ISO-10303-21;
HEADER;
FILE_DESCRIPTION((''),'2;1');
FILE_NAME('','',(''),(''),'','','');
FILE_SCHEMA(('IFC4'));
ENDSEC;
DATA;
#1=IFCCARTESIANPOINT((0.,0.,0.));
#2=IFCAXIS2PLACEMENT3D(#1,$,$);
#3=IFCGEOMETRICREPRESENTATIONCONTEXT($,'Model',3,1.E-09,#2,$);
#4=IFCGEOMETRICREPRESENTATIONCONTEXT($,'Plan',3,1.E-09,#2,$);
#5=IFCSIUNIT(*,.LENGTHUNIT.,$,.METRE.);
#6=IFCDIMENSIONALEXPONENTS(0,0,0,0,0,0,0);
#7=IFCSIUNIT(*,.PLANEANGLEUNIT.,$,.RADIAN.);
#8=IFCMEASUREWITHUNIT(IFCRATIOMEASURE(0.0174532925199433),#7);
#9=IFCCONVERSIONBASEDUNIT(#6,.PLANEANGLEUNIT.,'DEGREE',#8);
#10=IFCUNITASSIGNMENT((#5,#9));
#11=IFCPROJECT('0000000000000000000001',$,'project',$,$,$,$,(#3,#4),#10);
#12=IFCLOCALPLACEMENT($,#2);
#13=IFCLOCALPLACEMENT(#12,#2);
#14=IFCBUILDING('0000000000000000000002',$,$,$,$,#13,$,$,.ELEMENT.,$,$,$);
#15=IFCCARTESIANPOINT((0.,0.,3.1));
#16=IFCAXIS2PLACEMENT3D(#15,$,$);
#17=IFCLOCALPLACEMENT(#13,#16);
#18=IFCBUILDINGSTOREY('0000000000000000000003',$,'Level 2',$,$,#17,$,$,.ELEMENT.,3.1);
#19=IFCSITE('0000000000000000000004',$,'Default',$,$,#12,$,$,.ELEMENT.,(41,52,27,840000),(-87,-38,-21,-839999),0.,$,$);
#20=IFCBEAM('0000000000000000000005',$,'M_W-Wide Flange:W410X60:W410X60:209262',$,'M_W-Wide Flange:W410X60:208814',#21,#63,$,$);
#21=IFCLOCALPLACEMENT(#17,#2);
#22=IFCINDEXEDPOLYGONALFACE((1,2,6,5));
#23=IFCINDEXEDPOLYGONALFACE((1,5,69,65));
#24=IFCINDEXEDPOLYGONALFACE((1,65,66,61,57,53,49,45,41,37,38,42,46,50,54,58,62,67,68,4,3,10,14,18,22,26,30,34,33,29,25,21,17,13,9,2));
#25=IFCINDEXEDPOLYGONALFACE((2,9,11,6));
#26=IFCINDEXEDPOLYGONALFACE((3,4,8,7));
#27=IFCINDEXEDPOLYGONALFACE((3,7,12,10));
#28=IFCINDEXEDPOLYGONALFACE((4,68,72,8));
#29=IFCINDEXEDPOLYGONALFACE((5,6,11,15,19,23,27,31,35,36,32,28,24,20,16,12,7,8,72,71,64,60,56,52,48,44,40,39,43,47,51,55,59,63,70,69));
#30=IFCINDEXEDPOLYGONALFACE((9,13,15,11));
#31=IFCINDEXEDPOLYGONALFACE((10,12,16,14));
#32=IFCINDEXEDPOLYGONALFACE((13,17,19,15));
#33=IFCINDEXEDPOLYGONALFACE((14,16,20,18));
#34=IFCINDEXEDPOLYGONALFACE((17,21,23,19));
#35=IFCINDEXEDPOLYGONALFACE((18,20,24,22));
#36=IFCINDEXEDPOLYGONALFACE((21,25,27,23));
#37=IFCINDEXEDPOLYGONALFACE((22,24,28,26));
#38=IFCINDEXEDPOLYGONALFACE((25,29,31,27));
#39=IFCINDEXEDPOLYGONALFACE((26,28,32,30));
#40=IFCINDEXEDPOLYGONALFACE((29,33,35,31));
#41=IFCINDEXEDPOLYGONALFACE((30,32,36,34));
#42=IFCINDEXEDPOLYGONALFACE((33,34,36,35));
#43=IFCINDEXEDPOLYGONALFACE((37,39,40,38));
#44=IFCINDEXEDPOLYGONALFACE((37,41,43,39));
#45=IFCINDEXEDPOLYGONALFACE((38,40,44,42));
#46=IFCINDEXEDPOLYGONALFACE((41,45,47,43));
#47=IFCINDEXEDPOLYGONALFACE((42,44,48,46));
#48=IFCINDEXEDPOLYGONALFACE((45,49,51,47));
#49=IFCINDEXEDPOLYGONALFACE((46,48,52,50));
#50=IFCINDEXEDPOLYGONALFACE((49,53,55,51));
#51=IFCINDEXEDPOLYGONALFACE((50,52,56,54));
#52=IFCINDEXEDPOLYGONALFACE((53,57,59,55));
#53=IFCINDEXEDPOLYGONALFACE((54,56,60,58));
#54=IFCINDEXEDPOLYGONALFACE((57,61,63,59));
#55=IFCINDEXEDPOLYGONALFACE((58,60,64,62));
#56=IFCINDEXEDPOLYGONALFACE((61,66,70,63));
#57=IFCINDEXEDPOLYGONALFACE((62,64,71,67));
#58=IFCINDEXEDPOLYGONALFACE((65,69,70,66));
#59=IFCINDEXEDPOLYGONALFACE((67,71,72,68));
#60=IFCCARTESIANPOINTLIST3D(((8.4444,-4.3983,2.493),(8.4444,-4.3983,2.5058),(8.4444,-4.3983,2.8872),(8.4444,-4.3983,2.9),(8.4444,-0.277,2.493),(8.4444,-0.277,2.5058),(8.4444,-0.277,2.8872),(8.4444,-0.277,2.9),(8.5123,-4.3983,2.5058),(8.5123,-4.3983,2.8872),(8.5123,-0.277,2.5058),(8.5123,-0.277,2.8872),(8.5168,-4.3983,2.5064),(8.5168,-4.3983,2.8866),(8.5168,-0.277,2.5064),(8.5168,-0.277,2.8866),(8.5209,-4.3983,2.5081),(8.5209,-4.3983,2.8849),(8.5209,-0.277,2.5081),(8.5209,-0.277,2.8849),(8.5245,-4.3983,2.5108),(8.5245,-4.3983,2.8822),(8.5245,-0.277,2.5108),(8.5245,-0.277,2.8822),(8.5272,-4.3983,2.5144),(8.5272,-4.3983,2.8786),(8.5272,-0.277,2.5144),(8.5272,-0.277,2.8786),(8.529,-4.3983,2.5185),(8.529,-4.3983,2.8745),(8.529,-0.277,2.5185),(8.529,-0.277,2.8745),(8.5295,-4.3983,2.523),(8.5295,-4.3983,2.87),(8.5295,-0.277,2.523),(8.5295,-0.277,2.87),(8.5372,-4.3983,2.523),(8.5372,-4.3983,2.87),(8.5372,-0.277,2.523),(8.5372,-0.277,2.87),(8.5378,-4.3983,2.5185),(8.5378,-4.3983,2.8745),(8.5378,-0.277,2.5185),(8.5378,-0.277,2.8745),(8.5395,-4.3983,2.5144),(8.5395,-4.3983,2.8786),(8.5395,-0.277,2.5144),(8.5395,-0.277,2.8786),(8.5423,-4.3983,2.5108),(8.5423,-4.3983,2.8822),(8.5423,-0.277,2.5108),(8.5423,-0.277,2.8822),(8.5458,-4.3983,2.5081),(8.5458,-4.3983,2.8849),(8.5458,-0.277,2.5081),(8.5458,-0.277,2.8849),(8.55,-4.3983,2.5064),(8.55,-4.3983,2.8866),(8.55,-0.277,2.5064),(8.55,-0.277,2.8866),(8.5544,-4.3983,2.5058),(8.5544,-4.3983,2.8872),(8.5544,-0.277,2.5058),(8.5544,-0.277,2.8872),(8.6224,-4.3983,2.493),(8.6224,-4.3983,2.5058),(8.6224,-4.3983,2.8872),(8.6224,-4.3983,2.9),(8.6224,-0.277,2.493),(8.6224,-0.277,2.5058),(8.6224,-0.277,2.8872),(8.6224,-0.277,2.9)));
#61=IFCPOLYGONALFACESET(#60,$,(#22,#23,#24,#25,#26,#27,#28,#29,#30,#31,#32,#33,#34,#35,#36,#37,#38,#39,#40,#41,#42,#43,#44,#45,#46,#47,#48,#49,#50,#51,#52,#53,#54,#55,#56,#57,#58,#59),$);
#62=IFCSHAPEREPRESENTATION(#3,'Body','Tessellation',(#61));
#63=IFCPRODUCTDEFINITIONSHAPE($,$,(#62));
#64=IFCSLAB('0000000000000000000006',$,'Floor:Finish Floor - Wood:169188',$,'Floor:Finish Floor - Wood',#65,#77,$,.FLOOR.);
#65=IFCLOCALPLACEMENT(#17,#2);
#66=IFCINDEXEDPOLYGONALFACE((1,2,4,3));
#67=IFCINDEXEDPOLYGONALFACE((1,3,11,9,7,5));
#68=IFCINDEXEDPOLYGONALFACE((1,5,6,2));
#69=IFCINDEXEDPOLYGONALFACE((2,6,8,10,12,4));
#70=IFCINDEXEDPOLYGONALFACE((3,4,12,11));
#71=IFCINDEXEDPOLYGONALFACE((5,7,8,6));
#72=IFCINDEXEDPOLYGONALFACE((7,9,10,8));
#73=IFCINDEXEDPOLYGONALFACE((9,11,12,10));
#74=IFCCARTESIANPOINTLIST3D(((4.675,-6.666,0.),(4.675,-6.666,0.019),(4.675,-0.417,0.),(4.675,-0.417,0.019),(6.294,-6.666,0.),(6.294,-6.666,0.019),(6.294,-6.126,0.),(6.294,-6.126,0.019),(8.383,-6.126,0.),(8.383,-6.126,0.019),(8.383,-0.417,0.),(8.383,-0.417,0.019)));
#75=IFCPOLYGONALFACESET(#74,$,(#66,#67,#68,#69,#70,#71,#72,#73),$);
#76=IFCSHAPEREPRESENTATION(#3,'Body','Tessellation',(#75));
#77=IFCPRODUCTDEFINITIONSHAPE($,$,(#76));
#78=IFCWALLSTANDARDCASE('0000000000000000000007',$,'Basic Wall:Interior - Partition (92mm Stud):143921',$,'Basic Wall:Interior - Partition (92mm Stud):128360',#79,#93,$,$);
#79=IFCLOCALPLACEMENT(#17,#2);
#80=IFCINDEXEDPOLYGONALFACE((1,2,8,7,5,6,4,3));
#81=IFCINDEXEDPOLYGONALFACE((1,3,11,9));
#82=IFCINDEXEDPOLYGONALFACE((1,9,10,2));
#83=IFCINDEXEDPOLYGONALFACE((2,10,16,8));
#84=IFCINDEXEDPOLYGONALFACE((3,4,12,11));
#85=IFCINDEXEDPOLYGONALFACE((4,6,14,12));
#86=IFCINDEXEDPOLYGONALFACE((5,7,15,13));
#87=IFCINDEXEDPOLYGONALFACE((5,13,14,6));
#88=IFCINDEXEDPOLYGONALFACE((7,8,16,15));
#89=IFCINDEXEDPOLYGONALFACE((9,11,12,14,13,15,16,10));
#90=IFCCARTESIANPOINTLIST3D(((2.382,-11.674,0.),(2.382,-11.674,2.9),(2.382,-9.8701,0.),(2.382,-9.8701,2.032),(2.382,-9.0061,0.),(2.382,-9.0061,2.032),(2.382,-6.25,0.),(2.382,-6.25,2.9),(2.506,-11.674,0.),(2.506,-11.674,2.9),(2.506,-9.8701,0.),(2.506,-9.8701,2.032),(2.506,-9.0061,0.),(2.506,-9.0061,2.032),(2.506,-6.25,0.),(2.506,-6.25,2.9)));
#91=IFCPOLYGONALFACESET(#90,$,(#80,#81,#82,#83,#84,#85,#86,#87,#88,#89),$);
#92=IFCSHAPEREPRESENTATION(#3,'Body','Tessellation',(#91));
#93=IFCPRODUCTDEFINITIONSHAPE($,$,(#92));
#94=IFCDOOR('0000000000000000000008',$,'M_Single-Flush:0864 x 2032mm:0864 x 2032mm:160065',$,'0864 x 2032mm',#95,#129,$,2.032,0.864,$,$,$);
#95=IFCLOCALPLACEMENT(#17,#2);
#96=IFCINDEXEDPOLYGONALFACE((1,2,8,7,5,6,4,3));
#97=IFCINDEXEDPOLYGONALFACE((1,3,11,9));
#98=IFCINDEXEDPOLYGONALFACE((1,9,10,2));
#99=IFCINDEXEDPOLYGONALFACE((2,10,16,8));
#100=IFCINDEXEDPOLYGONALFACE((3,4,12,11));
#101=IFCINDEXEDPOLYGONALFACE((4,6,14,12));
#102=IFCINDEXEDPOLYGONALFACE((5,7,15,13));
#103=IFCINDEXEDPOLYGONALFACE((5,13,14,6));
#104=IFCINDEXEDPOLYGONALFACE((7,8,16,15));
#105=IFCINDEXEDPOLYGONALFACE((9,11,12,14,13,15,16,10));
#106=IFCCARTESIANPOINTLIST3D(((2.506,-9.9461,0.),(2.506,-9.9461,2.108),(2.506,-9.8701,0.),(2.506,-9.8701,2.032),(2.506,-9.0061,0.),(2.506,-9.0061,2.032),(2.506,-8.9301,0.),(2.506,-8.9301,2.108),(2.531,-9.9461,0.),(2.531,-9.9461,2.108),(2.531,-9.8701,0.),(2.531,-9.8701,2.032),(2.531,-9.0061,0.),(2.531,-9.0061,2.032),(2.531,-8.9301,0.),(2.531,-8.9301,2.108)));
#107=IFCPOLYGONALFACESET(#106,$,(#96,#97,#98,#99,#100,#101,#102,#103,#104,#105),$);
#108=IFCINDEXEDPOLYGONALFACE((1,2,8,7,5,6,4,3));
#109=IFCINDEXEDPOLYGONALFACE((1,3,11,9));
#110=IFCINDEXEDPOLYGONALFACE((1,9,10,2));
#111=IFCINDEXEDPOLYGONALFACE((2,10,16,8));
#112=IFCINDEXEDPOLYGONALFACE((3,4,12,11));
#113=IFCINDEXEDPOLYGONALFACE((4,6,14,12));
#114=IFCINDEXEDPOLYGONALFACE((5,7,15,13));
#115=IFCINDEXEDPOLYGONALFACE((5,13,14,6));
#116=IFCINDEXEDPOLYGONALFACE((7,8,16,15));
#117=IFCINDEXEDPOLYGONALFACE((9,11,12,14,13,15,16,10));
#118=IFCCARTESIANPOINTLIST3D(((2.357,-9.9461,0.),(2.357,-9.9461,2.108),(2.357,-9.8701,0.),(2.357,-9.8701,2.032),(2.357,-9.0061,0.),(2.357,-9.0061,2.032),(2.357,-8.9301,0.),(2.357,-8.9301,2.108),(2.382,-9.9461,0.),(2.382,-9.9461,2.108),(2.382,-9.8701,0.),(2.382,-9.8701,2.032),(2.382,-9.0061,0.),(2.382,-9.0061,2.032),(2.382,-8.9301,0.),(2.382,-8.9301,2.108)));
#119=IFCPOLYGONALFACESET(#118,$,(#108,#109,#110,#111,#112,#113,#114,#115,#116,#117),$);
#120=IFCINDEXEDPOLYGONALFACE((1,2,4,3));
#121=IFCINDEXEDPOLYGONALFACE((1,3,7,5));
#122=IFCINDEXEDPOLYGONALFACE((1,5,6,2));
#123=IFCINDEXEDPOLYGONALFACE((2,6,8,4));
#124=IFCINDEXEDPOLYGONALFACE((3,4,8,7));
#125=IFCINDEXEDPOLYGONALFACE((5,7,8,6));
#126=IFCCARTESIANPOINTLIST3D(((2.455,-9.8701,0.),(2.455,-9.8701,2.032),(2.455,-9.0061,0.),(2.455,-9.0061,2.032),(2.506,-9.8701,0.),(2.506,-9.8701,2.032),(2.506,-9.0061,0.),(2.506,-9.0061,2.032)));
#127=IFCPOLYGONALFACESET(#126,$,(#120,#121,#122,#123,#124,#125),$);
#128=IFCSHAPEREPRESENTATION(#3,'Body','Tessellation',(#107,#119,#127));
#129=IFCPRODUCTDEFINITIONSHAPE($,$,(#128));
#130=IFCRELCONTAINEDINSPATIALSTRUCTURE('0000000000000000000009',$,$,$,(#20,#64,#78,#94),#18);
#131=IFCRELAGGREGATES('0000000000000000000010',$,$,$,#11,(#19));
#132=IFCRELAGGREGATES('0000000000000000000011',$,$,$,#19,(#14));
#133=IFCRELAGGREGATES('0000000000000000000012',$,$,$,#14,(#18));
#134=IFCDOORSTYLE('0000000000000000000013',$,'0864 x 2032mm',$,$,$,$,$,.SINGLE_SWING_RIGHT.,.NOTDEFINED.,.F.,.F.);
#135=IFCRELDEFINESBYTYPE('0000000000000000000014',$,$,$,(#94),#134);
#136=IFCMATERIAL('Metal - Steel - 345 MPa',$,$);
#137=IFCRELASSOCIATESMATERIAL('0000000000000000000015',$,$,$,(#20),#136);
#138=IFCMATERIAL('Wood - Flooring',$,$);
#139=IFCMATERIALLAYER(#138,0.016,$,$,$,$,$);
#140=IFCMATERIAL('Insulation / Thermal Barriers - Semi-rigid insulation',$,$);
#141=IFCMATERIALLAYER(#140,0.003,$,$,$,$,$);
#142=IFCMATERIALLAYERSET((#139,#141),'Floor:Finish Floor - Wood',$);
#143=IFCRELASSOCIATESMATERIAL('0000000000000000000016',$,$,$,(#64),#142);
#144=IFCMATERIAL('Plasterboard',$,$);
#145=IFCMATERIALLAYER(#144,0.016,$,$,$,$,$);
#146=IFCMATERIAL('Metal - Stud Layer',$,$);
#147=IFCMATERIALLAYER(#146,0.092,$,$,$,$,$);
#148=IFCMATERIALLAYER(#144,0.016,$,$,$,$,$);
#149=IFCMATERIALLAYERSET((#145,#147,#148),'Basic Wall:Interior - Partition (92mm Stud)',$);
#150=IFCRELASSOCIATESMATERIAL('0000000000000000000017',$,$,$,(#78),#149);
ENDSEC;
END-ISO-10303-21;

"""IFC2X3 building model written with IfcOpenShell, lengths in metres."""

from ifc_helpers import new_model, entity, si_unit, converted_unit, frame, frame_2d, origin, origin_2d_with_axis, place, context, project, spatial, polyline, circle_curve, parameter, trimmed, segment, composite_curve, rectangle, outline, extrude, source, transform, mapped, material, layer, layer_set, layer_usage, type_object, type_shapes, element, fill, save


model = new_model("IFC2X3")

# Units and contexts
model_context = context("Model", 3, precision=1e-09, world=origin())
plan_context = context("Plan", 3, precision=1e-09, world=origin())
ifc_project = project(units=[si_unit("LENGTHUNIT", "METRE"), converted_unit("PLANEANGLEUNIT", "DEGREE", entity("IfcRatioMeasure", 0.0174532925199433), si_unit("PLANEANGLEUNIT", "RADIAN"), dimensions=[0, 0, 0, 0, 0, 0, 0])], contexts=[model_context, plan_context])

# Site, building, storey
site_placement = place(None, origin())
site = spatial("IfcSite", under=ifc_project, at=site_placement, Name="Default", CompositionType="ELEMENT", RefLatitude=(41, 52, 27, 840000), RefLongitude=(-87, -38, -21, -839999), RefElevation=0.0)
building_placement = place(site_placement, origin())
building = spatial("IfcBuilding", under=site, at=building_placement, CompositionType="ELEMENT")
storey_placement = place(building_placement, frame((0.0, 0.0, 3.1)))
storey = spatial("IfcBuildingStorey", under=building, at=storey_placement, Name="Level 2", CompositionType="ELEMENT", Elevation=3.1)

# Beam
ifc_material_1 = material(Name="Metal - Steel - 345 MPa")
beam_1_placement = place(storey_placement, frame((8.5334, -4.3983, 2.9)))
element("IfcBeam", 1, at=beam_1_placement, inside=storey, material=ifc_material_1, Name="M_W-Wide Flange:W410X60:W410X60:209262", ObjectType="M_W-Wide Flange:W410X60:208814", context=model_context, shape_type="SweptSolid", body=[
    extrude(outline(composite_curve([segment(polyline([(-0.089, -0.1907), (-0.089, -0.2035)]), True, "CONTINUOUS"), segment(polyline([(-0.089, -0.2035), (0.089, -0.2035)]), True, "CONTINUOUS"), segment(polyline([(0.089, -0.2035), (0.089, -0.1907)]), True, "CONTINUOUS"), segment(polyline([(0.089, -0.1907), (0.021, -0.1907)]), True, "CONTINUOUS"), segment(trimmed(circle_curve(frame_2d((0.021, -0.1735), x_axis=(0.0, -1.0)), 0.0172), [parameter(270.0)], [parameter(360.0)], True, "PARAMETER"), False, "CONTINUOUS"), segment(polyline([(0.0038, -0.1735), (0.0038, 0.1735)]), True, "CONTINUOUS"), segment(trimmed(circle_curve(frame_2d((0.021, 0.1735), x_axis=(-1.0, 0.0)), 0.0172), [parameter(270.0)], [parameter(360.0)], True, "PARAMETER"), False, "CONTINUOUS"), segment(polyline([(0.021, 0.1907), (0.089, 0.1907)]), True, "CONTINUOUS"), segment(polyline([(0.089, 0.1907), (0.089, 0.2035)]), True, "CONTINUOUS"), segment(polyline([(0.089, 0.2035), (-0.089, 0.2035)]), True, "CONTINUOUS"), segment(polyline([(-0.089, 0.2035), (-0.089, 0.1907)]), True, "CONTINUOUS"), segment(polyline([(-0.089, 0.1907), (-0.0211, 0.1907)]), True, "CONTINUOUS"), segment(trimmed(circle_curve(frame_2d((-0.0211, 0.1735), x_axis=(0.0, 1.0)), 0.0172), [parameter(270.0)], [parameter(0.0)], True, "PARAMETER"), False, "CONTINUOUS"), segment(polyline([(-0.0039, 0.1735), (-0.0039, -0.1735)]), True, "CONTINUOUS"), segment(trimmed(circle_curve(frame_2d((-0.0211, -0.1735), x_axis=(1.0, 0.0)), 0.0172), [parameter(270.0)], [parameter(0.0)], True, "PARAMETER"), False, "CONTINUOUS"), segment(polyline([(-0.0211, -0.1907), (-0.089, -0.1907)]), True, "CONTINUOUS")], self_intersect=False)), frame((0.0, 0.0, -0.2035), z_axis=(0.0, -1.0, 0.0), x_axis=(1.0, 0.0, 0.0)), (0.0, 0.0, -1.0), 4.1213),
])

# Slab
ifc_material_2 = material(Name="Wood - Flooring")
ifc_layer_1 = layer(ifc_material_2, 0.016)
ifc_material_3 = material(Name="Insulation / Thermal Barriers - Semi-rigid insulation")
ifc_layer_2 = layer(ifc_material_3, 0.003)
ifc_layer_set_1 = layer_set([ifc_layer_1, ifc_layer_2], Name="Floor:Finish Floor - Wood")
ifc_layer_usage_1 = layer_usage(ifc_layer_set_1, "AXIS3", "POSITIVE", 0.0)
slab_placement = place(storey_placement, frame((4.675, -6.666, 0.0)))
element("IfcSlab", 2, at=slab_placement, inside=storey, material=ifc_layer_usage_1, Name="Floor:Finish Floor - Wood:169188", ObjectType="Floor:Finish Floor - Wood", PredefinedType="FLOOR", context=model_context, shape_type="SweptSolid", body=[
    extrude(outline(polyline([(-1.854, 3.1245), (-1.854, -2.5845), (0.235, -2.5845), (0.235, -3.1245), (1.854, -3.1245), (1.854, 3.1245), (-1.854, 3.1245)])), frame((1.854, 3.1245, 0.019), z_axis=(0.0, 0.0, -1.0), x_axis=(-1.0, 0.0, 0.0)), (0.0, 0.0, 1.0), 0.019),
])

# Shared definitions
ifc_material_4 = material(Name="Metal - Stud Layer")
ifc_material_5 = material(Name="Plasterboard")

# Wall, opening, door
ifc_layer_3 = layer(ifc_material_5, 0.016)
ifc_layer_4 = layer(ifc_material_4, 0.092)
ifc_layer_5 = layer(ifc_material_5, 0.016)
ifc_layer_set_2 = layer_set([ifc_layer_3, ifc_layer_4, ifc_layer_5], Name="Basic Wall:Interior - Partition (92mm Stud)")
ifc_layer_usage_2 = layer_usage(ifc_layer_set_2, "AXIS2", "NEGATIVE", 0.062)
wall_1_placement = place(storey_placement, frame((2.444, -6.25, 0.0), z_axis=(0.0, 0.0, 1.0), x_axis=(0.0, -1.0, 0.0)))
wall_1 = element("IfcWallStandardCase", 3, at=wall_1_placement, inside=storey, material=ifc_layer_usage_2, Name="Basic Wall:Interior - Partition (92mm Stud):143921", ObjectType="Basic Wall:Interior - Partition (92mm Stud):128360", context=model_context, shape_type="SweptSolid", body=[
    extrude(rectangle(XDim=5.424, YDim=0.124, at=frame_2d((2.712, 0.0), x_axis=(-1.0, 0.0))), origin(), (0.0, 0.0, 1.0), 2.9),
])
opening_1_placement = place(wall_1_placement, frame((2.7561, -0.062, 0.0)))
opening_1 = element("IfcOpeningElement", 4, at=opening_1_placement, cuts=wall_1, ObjectType="Opening", context=model_context, shape_type="SweptSolid", body=[
    extrude(rectangle(XDim=0.864, YDim=2.032, at=frame_2d((1.016, 0.432), x_axis=(0.0, 1.0))), frame((0.0, 0.0, 0.0), z_axis=(0.0, 1.0, 0.0), x_axis=(0.0, 0.0, 1.0)), (0.0, 0.0, 1.0), 0.124),
])
door_style_1 = type_object("IfcDoorStyle", Name="0864 x 2032mm", ConstructionType="NOTDEFINED", OperationType="SINGLE_SWING_RIGHT", ParameterTakesPrecedence=False, Sizeable=False)
shared_shape_1 = source(origin(), model_context, "Body", "SweptSolid", [
    extrude(outline(polyline([(-0.508, -1.073), (0.508, -1.073), (0.508, 1.035), (0.432, 1.035), (0.432, -0.997), (-0.432, -0.997), (-0.432, 1.035), (-0.508, 1.035), (-0.508, -1.073)])), frame((0.432, 0.124, 1.035), z_axis=(0.0, 1.0, 0.0), x_axis=(1.0, 0.0, 0.0)), (0.0, 0.0, 1.0), 0.025),
    extrude(outline(polyline([(-1.073, -0.508), (1.035, -0.508), (1.035, -0.432), (-0.997, -0.432), (-0.997, 0.432), (1.035, 0.432), (1.035, 0.508), (-1.073, 0.508), (-1.073, -0.508)])), frame((0.432, -0.025, 1.035), z_axis=(0.0, 1.0, 0.0), x_axis=(0.0, 0.0, -1.0)), (0.0, 0.0, 1.0), 0.025),
    extrude(rectangle(XDim=0.051, YDim=0.864, at=origin_2d_with_axis()), frame((0.432, 0.0985, 0.0), z_axis=(0.0, 0.0, 1.0), x_axis=(0.0, 1.0, 0.0)), (0.0, 0.0, 1.0), 2.032),
])
type_shapes(door_style_1, [shared_shape_1])
door_1_placement = place(opening_1_placement, origin())
door_1 = element("IfcDoor", 5, at=door_1_placement, inside=storey, type_object=door_style_1, Name="M_Single-Flush:0864 x 2032mm:0864 x 2032mm:160065", ObjectType="0864 x 2032mm", OverallHeight=2.032, OverallWidth=0.864, context=model_context, shape_type="MappedRepresentation", body=[
    mapped(shared_shape_1, transform((0.0, 0.0, 0.0), scale=1.0)),
])
fill(opening_1, door_1)

save(model, "model.ifc")
